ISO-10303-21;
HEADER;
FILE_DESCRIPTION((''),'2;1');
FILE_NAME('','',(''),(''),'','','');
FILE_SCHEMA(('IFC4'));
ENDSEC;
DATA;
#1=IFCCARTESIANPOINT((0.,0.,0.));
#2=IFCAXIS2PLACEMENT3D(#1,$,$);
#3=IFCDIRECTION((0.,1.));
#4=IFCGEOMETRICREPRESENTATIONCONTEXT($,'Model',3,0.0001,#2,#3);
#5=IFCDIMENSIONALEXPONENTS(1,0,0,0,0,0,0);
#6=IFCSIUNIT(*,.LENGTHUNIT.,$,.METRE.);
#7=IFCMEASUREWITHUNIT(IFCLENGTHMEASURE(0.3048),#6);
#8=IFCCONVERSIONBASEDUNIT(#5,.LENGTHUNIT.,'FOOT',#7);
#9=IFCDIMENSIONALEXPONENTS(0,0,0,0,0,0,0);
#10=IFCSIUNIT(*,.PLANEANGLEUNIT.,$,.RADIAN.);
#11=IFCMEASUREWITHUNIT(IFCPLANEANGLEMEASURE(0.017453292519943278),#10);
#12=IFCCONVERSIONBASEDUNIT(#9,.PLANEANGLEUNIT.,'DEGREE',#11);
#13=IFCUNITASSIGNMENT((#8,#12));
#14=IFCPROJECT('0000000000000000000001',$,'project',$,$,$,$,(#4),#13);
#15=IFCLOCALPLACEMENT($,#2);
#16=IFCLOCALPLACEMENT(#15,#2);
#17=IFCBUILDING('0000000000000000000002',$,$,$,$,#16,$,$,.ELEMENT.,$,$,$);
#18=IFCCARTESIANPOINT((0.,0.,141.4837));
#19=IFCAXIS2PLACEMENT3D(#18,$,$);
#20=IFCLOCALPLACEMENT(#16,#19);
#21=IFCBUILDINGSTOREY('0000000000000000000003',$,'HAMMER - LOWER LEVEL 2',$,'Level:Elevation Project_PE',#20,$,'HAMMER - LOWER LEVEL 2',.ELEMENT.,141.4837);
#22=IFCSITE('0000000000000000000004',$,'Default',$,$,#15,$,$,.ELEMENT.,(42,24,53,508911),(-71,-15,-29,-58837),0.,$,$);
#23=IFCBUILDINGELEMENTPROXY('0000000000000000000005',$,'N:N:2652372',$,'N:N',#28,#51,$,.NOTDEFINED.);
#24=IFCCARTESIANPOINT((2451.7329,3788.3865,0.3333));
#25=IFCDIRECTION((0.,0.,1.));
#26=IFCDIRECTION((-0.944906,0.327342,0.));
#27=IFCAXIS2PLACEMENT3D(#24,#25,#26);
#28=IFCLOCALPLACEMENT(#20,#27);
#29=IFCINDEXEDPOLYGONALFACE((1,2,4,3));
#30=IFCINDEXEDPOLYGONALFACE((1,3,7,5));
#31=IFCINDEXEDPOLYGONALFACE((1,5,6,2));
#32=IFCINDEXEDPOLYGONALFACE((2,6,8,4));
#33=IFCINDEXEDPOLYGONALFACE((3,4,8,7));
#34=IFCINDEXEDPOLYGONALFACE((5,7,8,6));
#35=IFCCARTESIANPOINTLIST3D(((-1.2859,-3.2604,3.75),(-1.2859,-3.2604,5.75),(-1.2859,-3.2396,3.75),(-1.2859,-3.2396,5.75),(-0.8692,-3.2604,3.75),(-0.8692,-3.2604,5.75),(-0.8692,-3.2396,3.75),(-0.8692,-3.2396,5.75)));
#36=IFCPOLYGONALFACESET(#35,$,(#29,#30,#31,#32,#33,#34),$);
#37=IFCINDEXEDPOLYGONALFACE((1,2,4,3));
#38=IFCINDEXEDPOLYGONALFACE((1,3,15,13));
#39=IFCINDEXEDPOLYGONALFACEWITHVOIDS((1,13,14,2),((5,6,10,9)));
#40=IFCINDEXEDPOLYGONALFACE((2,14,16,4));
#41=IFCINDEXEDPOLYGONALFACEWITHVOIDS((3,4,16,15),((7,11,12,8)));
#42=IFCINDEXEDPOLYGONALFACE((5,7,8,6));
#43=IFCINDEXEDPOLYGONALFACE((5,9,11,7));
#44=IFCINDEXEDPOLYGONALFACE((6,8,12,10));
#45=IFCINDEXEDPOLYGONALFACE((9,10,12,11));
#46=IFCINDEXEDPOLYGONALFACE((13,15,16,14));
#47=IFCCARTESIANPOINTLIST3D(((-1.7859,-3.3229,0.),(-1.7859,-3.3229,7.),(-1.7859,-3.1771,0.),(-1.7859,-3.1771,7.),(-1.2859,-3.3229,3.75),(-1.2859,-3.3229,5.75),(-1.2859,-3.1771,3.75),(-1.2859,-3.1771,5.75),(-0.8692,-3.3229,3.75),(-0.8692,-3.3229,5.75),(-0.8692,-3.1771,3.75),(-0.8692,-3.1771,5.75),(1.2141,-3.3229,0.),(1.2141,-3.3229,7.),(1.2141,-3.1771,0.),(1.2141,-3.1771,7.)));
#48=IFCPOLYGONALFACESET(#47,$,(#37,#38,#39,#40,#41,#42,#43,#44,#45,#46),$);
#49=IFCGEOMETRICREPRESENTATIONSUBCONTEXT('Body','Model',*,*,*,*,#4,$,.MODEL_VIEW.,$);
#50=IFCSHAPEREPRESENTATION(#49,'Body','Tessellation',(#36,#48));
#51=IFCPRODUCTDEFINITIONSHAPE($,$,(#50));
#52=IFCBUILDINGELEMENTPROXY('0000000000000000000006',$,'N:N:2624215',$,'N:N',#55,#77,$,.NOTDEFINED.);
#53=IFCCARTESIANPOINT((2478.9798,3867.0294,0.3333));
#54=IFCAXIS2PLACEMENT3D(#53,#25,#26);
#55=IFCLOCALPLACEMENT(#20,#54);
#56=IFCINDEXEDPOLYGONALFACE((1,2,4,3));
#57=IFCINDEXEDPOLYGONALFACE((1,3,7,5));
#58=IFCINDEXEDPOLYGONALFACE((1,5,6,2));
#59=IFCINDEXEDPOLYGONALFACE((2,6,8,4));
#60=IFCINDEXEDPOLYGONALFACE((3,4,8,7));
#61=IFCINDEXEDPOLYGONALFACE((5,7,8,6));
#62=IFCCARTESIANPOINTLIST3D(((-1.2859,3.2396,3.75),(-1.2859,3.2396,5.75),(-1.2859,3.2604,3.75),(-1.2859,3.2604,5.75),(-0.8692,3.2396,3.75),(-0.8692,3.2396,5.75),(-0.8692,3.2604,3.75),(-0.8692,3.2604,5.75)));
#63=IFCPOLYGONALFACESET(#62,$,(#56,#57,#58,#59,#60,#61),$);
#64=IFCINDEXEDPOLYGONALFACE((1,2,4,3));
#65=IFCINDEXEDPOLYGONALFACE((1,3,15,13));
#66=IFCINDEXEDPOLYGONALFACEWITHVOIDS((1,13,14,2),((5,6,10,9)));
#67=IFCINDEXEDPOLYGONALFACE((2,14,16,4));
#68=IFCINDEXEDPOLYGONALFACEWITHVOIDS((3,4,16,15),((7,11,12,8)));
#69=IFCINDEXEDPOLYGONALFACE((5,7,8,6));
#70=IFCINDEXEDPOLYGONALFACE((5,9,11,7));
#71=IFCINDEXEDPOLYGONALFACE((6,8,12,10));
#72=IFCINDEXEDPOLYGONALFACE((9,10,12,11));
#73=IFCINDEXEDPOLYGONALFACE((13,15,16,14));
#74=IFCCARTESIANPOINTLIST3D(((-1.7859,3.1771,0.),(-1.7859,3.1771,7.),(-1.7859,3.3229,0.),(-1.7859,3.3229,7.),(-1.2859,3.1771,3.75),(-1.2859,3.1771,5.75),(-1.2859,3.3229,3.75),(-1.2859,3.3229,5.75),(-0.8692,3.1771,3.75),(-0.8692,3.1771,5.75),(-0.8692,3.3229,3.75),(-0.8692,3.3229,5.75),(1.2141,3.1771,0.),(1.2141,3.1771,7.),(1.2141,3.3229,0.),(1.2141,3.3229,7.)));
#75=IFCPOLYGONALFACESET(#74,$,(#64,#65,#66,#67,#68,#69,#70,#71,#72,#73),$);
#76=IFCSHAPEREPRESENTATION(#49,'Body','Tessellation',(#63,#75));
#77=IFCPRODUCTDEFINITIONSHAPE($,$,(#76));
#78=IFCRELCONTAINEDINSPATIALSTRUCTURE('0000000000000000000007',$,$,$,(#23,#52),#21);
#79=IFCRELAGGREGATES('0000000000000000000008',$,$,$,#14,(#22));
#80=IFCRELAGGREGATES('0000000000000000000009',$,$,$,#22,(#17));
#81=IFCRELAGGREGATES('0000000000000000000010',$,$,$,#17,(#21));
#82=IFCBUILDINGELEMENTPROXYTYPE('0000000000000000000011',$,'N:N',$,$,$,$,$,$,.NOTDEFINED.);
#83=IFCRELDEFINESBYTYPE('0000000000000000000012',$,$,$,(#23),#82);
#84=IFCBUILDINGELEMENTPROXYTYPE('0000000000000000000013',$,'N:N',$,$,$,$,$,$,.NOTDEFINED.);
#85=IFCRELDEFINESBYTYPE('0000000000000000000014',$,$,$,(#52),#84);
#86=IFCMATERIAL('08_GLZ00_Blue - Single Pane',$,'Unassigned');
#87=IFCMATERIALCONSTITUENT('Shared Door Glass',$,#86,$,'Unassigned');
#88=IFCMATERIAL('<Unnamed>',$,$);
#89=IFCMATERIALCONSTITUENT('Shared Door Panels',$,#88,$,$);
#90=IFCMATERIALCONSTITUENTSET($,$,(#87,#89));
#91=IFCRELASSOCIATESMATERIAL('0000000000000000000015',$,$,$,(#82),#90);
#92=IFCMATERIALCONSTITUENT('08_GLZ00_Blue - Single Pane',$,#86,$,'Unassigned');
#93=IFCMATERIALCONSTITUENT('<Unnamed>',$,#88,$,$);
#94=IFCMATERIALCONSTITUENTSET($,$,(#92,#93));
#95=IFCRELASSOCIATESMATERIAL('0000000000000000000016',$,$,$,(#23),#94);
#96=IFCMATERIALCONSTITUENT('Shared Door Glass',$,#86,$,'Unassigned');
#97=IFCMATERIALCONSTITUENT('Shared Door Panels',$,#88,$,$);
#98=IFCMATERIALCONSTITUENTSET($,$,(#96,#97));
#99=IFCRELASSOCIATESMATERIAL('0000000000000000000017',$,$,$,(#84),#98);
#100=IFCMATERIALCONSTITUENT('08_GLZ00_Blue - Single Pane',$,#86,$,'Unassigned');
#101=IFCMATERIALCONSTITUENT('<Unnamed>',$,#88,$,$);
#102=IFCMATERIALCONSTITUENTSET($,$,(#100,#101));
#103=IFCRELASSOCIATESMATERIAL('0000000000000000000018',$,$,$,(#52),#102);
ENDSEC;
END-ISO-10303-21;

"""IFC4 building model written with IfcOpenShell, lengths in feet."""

from ifc_helpers import new_model, entity, si_unit, converted_unit, direction, frame, origin, place, context, subcontext, project, spatial, indexed_curve, outline, extrude, source, transform, mapped, material, constituent, constituent_set, type_object, type_shapes, element, save


model = new_model("IFC4")

# Units and contexts
model_context = context("Model", 3, precision=0.0001, world=origin(), true_north=direction((0.0, 1.0)))
body_context = subcontext(model_context, "Body", "Model", "MODEL_VIEW")
ifc_project = project(units=[converted_unit("LENGTHUNIT", "FOOT", entity("IfcLengthMeasure", 0.3048), si_unit("LENGTHUNIT", "METRE"), dimensions=[1, 0, 0, 0, 0, 0, 0]), converted_unit("PLANEANGLEUNIT", "DEGREE", entity("IfcPlaneAngleMeasure", 0.017453292519943278), si_unit("PLANEANGLEUNIT", "RADIAN"), dimensions=[0, 0, 0, 0, 0, 0, 0])], contexts=[model_context])

# Site, building, storey
site_placement = place(None, origin())
site = spatial("IfcSite", under=ifc_project, at=site_placement, Name="Default", CompositionType="ELEMENT", RefLatitude=(42, 24, 53, 508911), RefLongitude=(-71, -15, -29, -58837), RefElevation=0.0)
building_placement = place(site_placement, origin())
building = spatial("IfcBuilding", under=site, at=building_placement, CompositionType="ELEMENT")
storey_placement = place(building_placement, frame((0.0, 0.0, 141.4837)))
storey = spatial("IfcBuildingStorey", under=building, at=storey_placement, Name="HAMMER - LOWER LEVEL 2", ObjectType="Level:Elevation Project_PE", LongName="HAMMER - LOWER LEVEL 2", CompositionType="ELEMENT", Elevation=141.4837)

# Shared definitions
ifc_material_1 = material(Name="<Unnamed>")

# Building element proxies
ifc_material_2 = material(Name="08_GLZ00_Blue - Single Pane", Category="Unassigned")
ifc_constituent_1 = constituent(ifc_material_2, Name="08_GLZ00_Blue - Single Pane", Category="Unassigned")
ifc_constituent_2 = constituent(ifc_material_1, Name="<Unnamed>")
ifc_constituent_set_1 = constituent_set(constituents=[ifc_constituent_1, ifc_constituent_2])
ifc_constituent_3 = constituent(ifc_material_2, Name="Shared Door Glass", Category="Unassigned")
ifc_constituent_4 = constituent(ifc_material_1, Name="Shared Door Panels")
ifc_constituent_set_2 = constituent_set(constituents=[ifc_constituent_3, ifc_constituent_4])
building_element_proxy_type_1 = type_object("IfcBuildingElementProxyType", Name="N:N", PredefinedType="NOTDEFINED", material=ifc_constituent_set_2)
shared_shape_1 = source(origin(), body_context, "Body", "SweptSolid", [
    extrude(outline(indexed_curve([(-0.2083, -0.0104), (0.2083, -0.0104), (0.2083, 0.0104), (-0.2083, 0.0104), (-0.2083, -0.0104)], self_intersect=False)), frame((-1.0775, -3.25, 3.75), z_axis=(0.0, 0.0, 1.0), x_axis=(-1.0, 0.0, 0.0)), (0.0, 0.0, 1.0), 2.0),
    extrude(outline(indexed_curve([(-3.5, -1.5), (3.5, -1.5), (3.5, 1.5), (-3.5, 1.5), (-3.5, -1.5)], self_intersect=False), holes=[indexed_curve([(-2.25, 0.5833), (-2.25, 1.0), (-0.25, 1.0), (-0.25, 0.5833), (-2.25, 0.5833)], self_intersect=False)]), frame((-0.2859, -3.3229, 3.5), z_axis=(0.0, 1.0, 0.0), x_axis=(0.0, 0.0, -1.0)), (0.0, 0.0, 1.0), 0.1458),
])
type_shapes(building_element_proxy_type_1, [shared_shape_1])
proxy_1_placement = place(storey_placement, frame((2451.7329, 3788.3865, 0.3333), z_axis=(0.0, 0.0, 1.0), x_axis=(-0.944906, 0.327342, 0.0)))
element("IfcBuildingElementProxy", 1, at=proxy_1_placement, inside=storey, type_object=building_element_proxy_type_1, material=ifc_constituent_set_1, Name="N:N:2652372", ObjectType="N:N", PredefinedType="NOTDEFINED", context=body_context, shape_type="MappedRepresentation", body=[
    mapped(shared_shape_1, transform((0.0, 0.0, 0.0), scale=1.0)),
])
ifc_constituent_5 = constituent(ifc_material_2, Name="08_GLZ00_Blue - Single Pane", Category="Unassigned")
ifc_constituent_6 = constituent(ifc_material_1, Name="<Unnamed>")
ifc_constituent_set_3 = constituent_set(constituents=[ifc_constituent_5, ifc_constituent_6])
ifc_constituent_7 = constituent(ifc_material_2, Name="Shared Door Glass", Category="Unassigned")
ifc_constituent_8 = constituent(ifc_material_1, Name="Shared Door Panels")
ifc_constituent_set_4 = constituent_set(constituents=[ifc_constituent_7, ifc_constituent_8])
building_element_proxy_type_2 = type_object("IfcBuildingElementProxyType", Name="N:N", PredefinedType="NOTDEFINED", material=ifc_constituent_set_4)
shared_shape_2 = source(origin(), body_context, "Body", "SweptSolid", [
    extrude(outline(indexed_curve([(-0.0104, -0.2083), (0.0104, -0.2083), (0.0104, 0.2083), (-0.0104, 0.2083), (-0.0104, -0.2083)], self_intersect=False)), frame((-1.0775, 3.25, 3.75), z_axis=(0.0, 0.0, 1.0), x_axis=(0.0, 1.0, 0.0)), (0.0, 0.0, 1.0), 2.0),
    extrude(outline(indexed_curve([(-3.5, -1.5), (3.5, -1.5), (3.5, 1.5), (-3.5, 1.5), (-3.5, -1.5)], self_intersect=False), holes=[indexed_curve([(-2.25, 0.5833), (-2.25, 1.0), (-0.25, 1.0), (-0.25, 0.5833), (-2.25, 0.5833)], self_intersect=False)]), frame((-0.2859, 3.1771, 3.5), z_axis=(0.0, 1.0, 0.0), x_axis=(0.0, 0.0, -1.0)), (0.0, 0.0, 1.0), 0.1458),
])
type_shapes(building_element_proxy_type_2, [shared_shape_2])
proxy_2_placement = place(storey_placement, frame((2478.9798, 3867.0294, 0.3333), z_axis=(0.0, 0.0, 1.0), x_axis=(-0.944906, 0.327342, 0.0)))
element("IfcBuildingElementProxy", 2, at=proxy_2_placement, inside=storey, type_object=building_element_proxy_type_2, material=ifc_constituent_set_3, Name="N:N:2624215", ObjectType="N:N", PredefinedType="NOTDEFINED", context=body_context, shape_type="MappedRepresentation", body=[
    mapped(shared_shape_2, transform((0.0, 0.0, 0.0), scale=1.0)),
])

save(model, "model.ifc")
